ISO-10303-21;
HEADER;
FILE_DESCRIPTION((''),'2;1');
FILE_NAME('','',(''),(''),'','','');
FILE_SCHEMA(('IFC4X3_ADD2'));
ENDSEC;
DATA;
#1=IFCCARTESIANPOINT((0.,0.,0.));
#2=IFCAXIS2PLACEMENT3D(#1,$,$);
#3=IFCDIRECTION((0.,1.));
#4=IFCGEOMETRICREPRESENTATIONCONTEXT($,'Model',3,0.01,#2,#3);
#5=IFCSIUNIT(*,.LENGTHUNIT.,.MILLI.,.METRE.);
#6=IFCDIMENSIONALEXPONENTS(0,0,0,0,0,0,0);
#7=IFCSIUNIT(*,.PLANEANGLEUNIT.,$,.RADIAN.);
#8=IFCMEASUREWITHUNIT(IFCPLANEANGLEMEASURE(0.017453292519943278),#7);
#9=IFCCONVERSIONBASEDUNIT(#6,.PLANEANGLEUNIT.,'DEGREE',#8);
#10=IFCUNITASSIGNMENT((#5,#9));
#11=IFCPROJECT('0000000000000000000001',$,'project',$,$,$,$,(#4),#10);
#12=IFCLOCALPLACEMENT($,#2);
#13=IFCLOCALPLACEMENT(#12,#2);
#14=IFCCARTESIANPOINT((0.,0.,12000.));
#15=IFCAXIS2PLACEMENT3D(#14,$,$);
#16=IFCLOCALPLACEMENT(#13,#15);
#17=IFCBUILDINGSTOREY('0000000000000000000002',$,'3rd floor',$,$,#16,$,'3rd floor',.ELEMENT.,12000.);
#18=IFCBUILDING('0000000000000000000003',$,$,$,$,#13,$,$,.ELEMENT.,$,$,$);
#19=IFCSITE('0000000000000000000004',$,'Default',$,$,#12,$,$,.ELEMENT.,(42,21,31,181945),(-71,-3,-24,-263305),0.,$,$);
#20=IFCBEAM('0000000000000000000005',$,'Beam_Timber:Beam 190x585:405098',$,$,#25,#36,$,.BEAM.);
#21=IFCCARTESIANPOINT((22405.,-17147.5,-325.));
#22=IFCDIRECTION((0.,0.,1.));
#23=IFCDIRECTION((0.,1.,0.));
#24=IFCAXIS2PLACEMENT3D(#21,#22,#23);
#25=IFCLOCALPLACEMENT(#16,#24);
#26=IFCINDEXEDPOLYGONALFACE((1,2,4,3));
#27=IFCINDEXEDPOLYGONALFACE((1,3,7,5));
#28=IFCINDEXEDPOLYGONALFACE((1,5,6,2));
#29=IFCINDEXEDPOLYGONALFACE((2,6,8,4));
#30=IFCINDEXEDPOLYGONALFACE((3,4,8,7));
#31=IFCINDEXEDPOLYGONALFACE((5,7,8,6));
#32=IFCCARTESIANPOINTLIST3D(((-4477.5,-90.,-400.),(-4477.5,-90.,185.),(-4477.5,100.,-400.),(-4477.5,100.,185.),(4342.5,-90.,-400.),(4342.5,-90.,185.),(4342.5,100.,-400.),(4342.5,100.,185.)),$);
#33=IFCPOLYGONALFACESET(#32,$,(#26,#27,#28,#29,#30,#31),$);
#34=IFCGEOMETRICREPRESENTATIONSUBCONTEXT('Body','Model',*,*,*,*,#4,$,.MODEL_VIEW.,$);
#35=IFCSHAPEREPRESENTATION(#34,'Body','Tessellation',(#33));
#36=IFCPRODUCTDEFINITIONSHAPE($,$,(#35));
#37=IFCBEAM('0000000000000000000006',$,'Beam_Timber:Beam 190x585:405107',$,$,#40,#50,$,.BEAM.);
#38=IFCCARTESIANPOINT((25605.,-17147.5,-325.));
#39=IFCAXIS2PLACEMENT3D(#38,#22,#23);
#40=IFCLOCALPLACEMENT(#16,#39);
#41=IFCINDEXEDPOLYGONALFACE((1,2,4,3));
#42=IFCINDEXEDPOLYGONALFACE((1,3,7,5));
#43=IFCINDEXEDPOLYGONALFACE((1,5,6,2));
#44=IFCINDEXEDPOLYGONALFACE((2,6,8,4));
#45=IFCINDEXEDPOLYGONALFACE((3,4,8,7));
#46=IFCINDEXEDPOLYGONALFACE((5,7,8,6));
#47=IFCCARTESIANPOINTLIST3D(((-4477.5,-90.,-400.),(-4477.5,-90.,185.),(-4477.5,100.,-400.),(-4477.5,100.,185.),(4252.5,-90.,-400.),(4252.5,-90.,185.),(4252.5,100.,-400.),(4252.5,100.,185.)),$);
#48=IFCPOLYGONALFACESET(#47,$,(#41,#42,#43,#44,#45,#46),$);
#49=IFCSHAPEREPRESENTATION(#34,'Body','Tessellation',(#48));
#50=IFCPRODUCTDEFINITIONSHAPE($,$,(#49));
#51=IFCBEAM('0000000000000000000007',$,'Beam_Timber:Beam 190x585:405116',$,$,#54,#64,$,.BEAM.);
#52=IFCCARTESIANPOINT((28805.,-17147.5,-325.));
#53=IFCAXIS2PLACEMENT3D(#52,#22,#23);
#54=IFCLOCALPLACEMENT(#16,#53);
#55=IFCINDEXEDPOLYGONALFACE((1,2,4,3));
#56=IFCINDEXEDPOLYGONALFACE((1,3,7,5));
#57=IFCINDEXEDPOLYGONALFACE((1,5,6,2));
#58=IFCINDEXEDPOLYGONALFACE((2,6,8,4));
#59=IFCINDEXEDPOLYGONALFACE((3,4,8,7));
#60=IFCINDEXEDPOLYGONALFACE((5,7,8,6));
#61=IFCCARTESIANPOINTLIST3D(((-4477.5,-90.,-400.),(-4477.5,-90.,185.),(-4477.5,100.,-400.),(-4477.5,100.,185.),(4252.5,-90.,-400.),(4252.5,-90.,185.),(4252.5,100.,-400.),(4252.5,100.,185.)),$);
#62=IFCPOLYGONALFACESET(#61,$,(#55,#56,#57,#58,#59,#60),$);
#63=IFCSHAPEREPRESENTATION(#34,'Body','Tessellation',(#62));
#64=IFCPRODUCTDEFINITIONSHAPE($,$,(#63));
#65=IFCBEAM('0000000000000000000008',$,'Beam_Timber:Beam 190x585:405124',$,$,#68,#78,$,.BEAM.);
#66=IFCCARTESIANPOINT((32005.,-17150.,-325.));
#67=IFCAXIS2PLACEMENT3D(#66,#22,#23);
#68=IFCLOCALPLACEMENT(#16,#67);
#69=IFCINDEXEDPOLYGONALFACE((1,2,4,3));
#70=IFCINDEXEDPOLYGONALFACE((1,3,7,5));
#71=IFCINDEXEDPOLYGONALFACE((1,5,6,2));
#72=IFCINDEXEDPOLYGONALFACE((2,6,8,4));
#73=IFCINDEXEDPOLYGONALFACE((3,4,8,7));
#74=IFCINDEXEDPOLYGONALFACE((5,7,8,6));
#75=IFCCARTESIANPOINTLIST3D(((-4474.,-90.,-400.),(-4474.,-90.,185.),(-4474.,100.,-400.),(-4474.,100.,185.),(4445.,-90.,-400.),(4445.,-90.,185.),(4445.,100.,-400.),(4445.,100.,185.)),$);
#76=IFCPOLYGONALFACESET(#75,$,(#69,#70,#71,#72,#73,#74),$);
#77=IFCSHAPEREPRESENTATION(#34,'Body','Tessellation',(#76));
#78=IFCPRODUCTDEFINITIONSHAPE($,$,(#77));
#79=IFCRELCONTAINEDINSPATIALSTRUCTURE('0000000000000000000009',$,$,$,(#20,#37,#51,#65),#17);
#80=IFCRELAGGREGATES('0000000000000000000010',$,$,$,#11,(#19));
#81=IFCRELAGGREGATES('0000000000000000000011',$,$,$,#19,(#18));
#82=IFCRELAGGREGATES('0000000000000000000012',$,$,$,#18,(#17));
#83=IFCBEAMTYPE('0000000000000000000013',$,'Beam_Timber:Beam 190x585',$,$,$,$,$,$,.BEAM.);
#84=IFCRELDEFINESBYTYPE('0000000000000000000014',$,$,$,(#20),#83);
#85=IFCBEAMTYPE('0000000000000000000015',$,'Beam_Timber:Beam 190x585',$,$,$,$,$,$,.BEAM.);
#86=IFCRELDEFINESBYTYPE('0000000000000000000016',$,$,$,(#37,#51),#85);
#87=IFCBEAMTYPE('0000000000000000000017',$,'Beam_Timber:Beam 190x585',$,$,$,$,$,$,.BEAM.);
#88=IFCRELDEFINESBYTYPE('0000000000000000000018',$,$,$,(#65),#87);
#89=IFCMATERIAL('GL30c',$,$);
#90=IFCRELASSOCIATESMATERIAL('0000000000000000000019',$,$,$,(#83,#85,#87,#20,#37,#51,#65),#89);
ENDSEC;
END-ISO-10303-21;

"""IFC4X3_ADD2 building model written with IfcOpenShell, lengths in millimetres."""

from ifc_helpers import new_model, entity, si_unit, converted_unit, direction, frame, origin, origin_2d_with_axis, place, context, subcontext, project, spatial, rectangle, extrude, source, transform, mapped, material, material_profile, profile_set, profile_usage, type_object, type_shapes, element, save


model = new_model("IFC4X3_ADD2")

# Units and contexts
model_context = context("Model", 3, precision=0.01, world=origin(), true_north=direction((0.0, 1.0)))
body_context = subcontext(model_context, "Body", "Model", "MODEL_VIEW")
ifc_project = project(units=[si_unit("LENGTHUNIT", "METRE", prefix="MILLI"), converted_unit("PLANEANGLEUNIT", "DEGREE", entity("IfcPlaneAngleMeasure", 0.017453292519943278), si_unit("PLANEANGLEUNIT", "RADIAN"), dimensions=[0, 0, 0, 0, 0, 0, 0])], contexts=[model_context])

# Site, building, storey
site_placement = place(None, origin())
site = spatial("IfcSite", under=ifc_project, at=site_placement, Name="Default", CompositionType="ELEMENT", RefLatitude=(42, 21, 31, 181945), RefLongitude=(-71, -3, -24, -263305), RefElevation=0.0)
building_placement = place(site_placement, origin())
building = spatial("IfcBuilding", under=site, at=building_placement, CompositionType="ELEMENT")
storey_placement = place(building_placement, frame((0.0, 0.0, 12000.0)))
storey = spatial("IfcBuildingStorey", under=building, at=storey_placement, Name="3rd floor", LongName="3rd floor", CompositionType="ELEMENT", Elevation=12000.0)

# Beams
ifc_material_1 = material(Name="GL30c")
ifc_material_profile_1 = material_profile(ifc_material_1, rectangle(XDim=5490.0, YDim=190.0, at=origin_2d_with_axis()), Name="Beam 190x585")
ifc_profile_set_1 = profile_set([ifc_material_profile_1], Name="Beam 190x585")
ifc_profile_usage_1 = profile_usage(ifc_profile_set_1, cardinal=8)
beam_type_1 = type_object("IfcBeamType", Name="Beam_Timber:Beam 190x585", PredefinedType="BEAM", material=ifc_profile_set_1)
shared_shape_1 = source(origin(), body_context, "Body", "SweptSolid", [
    extrude(rectangle(XDim=8820.0, YDim=190.0, at=origin_2d_with_axis()), frame((-67.5, 5.0, -400.0), z_axis=(0.0, 0.0, 1.0), x_axis=(-1.0, 0.0, 0.0)), (0.0, 0.0, 1.0), 585.0),
])
type_shapes(beam_type_1, [shared_shape_1])
beam_1_placement = place(storey_placement, frame((22405.0, -17147.5, -325.0), z_axis=(0.0, 0.0, 1.0), x_axis=(0.0, 1.0, 0.0)))
element("IfcBeam", 1, at=beam_1_placement, inside=storey, type_object=beam_type_1, material=ifc_profile_usage_1, Name="Beam_Timber:Beam 190x585:405098", PredefinedType="BEAM", context=body_context, shape_type="MappedRepresentation", body=[
    mapped(shared_shape_1, transform((0.0, 0.0, 0.0), scale=1.0)),
])
beam_type_2 = type_object("IfcBeamType", Name="Beam_Timber:Beam 190x585", PredefinedType="BEAM", material=ifc_profile_set_1)
shared_shape_2 = source(origin(), body_context, "Body", "SweptSolid", [
    extrude(rectangle(XDim=8730.0, YDim=190.0, at=origin_2d_with_axis()), frame((-112.5, 5.0, -400.0), z_axis=(0.0, 0.0, 1.0), x_axis=(-1.0, 0.0, 0.0)), (0.0, 0.0, 1.0), 585.0),
])
type_shapes(beam_type_2, [shared_shape_2])
for number, where, z_axis, x_axis, name in (
    (2, (25605.0, -17147.5, -325.0), (0.0, 0.0, 1.0), (0.0, 1.0, 0.0), "Beam_Timber:Beam 190x585:405107"),
    (3, (28805.0, -17147.5, -325.0), (0.0, 0.0, 1.0), (0.0, 1.0, 0.0), "Beam_Timber:Beam 190x585:405116"),
):
    element("IfcBeam", number, at=place(storey_placement, frame(where, z_axis=z_axis, x_axis=x_axis)), inside=storey, type_object=beam_type_2, material=ifc_profile_usage_1, Name=name, PredefinedType="BEAM", context=body_context, shape_type="MappedRepresentation", body=[
        mapped(shared_shape_2, transform((0.0, 0.0, 0.0), scale=1.0)),
    ])
beam_type_3 = type_object("IfcBeamType", Name="Beam_Timber:Beam 190x585", PredefinedType="BEAM", material=ifc_profile_set_1)
shared_shape_3 = source(origin(), body_context, "Body", "SweptSolid", [
    extrude(rectangle(XDim=8919.0, YDim=190.0, at=origin_2d_with_axis()), frame((-14.5, 5.0, -400.0), z_axis=(0.0, 0.0, 1.0), x_axis=(-1.0, 0.0, 0.0)), (0.0, 0.0, 1.0), 585.0),
])
type_shapes(beam_type_3, [shared_shape_3])
beam_2_placement = place(storey_placement, frame((32005.0, -17150.0, -325.0), z_axis=(0.0, 0.0, 1.0), x_axis=(0.0, 1.0, 0.0)))
element("IfcBeam", 4, at=beam_2_placement, inside=storey, type_object=beam_type_3, material=ifc_profile_usage_1, Name="Beam_Timber:Beam 190x585:405124", PredefinedType="BEAM", context=body_context, shape_type="MappedRepresentation", body=[
    mapped(shared_shape_3, transform((0.0, 0.0, 0.0), scale=1.0)),
])

save(model, "model.ifc")
